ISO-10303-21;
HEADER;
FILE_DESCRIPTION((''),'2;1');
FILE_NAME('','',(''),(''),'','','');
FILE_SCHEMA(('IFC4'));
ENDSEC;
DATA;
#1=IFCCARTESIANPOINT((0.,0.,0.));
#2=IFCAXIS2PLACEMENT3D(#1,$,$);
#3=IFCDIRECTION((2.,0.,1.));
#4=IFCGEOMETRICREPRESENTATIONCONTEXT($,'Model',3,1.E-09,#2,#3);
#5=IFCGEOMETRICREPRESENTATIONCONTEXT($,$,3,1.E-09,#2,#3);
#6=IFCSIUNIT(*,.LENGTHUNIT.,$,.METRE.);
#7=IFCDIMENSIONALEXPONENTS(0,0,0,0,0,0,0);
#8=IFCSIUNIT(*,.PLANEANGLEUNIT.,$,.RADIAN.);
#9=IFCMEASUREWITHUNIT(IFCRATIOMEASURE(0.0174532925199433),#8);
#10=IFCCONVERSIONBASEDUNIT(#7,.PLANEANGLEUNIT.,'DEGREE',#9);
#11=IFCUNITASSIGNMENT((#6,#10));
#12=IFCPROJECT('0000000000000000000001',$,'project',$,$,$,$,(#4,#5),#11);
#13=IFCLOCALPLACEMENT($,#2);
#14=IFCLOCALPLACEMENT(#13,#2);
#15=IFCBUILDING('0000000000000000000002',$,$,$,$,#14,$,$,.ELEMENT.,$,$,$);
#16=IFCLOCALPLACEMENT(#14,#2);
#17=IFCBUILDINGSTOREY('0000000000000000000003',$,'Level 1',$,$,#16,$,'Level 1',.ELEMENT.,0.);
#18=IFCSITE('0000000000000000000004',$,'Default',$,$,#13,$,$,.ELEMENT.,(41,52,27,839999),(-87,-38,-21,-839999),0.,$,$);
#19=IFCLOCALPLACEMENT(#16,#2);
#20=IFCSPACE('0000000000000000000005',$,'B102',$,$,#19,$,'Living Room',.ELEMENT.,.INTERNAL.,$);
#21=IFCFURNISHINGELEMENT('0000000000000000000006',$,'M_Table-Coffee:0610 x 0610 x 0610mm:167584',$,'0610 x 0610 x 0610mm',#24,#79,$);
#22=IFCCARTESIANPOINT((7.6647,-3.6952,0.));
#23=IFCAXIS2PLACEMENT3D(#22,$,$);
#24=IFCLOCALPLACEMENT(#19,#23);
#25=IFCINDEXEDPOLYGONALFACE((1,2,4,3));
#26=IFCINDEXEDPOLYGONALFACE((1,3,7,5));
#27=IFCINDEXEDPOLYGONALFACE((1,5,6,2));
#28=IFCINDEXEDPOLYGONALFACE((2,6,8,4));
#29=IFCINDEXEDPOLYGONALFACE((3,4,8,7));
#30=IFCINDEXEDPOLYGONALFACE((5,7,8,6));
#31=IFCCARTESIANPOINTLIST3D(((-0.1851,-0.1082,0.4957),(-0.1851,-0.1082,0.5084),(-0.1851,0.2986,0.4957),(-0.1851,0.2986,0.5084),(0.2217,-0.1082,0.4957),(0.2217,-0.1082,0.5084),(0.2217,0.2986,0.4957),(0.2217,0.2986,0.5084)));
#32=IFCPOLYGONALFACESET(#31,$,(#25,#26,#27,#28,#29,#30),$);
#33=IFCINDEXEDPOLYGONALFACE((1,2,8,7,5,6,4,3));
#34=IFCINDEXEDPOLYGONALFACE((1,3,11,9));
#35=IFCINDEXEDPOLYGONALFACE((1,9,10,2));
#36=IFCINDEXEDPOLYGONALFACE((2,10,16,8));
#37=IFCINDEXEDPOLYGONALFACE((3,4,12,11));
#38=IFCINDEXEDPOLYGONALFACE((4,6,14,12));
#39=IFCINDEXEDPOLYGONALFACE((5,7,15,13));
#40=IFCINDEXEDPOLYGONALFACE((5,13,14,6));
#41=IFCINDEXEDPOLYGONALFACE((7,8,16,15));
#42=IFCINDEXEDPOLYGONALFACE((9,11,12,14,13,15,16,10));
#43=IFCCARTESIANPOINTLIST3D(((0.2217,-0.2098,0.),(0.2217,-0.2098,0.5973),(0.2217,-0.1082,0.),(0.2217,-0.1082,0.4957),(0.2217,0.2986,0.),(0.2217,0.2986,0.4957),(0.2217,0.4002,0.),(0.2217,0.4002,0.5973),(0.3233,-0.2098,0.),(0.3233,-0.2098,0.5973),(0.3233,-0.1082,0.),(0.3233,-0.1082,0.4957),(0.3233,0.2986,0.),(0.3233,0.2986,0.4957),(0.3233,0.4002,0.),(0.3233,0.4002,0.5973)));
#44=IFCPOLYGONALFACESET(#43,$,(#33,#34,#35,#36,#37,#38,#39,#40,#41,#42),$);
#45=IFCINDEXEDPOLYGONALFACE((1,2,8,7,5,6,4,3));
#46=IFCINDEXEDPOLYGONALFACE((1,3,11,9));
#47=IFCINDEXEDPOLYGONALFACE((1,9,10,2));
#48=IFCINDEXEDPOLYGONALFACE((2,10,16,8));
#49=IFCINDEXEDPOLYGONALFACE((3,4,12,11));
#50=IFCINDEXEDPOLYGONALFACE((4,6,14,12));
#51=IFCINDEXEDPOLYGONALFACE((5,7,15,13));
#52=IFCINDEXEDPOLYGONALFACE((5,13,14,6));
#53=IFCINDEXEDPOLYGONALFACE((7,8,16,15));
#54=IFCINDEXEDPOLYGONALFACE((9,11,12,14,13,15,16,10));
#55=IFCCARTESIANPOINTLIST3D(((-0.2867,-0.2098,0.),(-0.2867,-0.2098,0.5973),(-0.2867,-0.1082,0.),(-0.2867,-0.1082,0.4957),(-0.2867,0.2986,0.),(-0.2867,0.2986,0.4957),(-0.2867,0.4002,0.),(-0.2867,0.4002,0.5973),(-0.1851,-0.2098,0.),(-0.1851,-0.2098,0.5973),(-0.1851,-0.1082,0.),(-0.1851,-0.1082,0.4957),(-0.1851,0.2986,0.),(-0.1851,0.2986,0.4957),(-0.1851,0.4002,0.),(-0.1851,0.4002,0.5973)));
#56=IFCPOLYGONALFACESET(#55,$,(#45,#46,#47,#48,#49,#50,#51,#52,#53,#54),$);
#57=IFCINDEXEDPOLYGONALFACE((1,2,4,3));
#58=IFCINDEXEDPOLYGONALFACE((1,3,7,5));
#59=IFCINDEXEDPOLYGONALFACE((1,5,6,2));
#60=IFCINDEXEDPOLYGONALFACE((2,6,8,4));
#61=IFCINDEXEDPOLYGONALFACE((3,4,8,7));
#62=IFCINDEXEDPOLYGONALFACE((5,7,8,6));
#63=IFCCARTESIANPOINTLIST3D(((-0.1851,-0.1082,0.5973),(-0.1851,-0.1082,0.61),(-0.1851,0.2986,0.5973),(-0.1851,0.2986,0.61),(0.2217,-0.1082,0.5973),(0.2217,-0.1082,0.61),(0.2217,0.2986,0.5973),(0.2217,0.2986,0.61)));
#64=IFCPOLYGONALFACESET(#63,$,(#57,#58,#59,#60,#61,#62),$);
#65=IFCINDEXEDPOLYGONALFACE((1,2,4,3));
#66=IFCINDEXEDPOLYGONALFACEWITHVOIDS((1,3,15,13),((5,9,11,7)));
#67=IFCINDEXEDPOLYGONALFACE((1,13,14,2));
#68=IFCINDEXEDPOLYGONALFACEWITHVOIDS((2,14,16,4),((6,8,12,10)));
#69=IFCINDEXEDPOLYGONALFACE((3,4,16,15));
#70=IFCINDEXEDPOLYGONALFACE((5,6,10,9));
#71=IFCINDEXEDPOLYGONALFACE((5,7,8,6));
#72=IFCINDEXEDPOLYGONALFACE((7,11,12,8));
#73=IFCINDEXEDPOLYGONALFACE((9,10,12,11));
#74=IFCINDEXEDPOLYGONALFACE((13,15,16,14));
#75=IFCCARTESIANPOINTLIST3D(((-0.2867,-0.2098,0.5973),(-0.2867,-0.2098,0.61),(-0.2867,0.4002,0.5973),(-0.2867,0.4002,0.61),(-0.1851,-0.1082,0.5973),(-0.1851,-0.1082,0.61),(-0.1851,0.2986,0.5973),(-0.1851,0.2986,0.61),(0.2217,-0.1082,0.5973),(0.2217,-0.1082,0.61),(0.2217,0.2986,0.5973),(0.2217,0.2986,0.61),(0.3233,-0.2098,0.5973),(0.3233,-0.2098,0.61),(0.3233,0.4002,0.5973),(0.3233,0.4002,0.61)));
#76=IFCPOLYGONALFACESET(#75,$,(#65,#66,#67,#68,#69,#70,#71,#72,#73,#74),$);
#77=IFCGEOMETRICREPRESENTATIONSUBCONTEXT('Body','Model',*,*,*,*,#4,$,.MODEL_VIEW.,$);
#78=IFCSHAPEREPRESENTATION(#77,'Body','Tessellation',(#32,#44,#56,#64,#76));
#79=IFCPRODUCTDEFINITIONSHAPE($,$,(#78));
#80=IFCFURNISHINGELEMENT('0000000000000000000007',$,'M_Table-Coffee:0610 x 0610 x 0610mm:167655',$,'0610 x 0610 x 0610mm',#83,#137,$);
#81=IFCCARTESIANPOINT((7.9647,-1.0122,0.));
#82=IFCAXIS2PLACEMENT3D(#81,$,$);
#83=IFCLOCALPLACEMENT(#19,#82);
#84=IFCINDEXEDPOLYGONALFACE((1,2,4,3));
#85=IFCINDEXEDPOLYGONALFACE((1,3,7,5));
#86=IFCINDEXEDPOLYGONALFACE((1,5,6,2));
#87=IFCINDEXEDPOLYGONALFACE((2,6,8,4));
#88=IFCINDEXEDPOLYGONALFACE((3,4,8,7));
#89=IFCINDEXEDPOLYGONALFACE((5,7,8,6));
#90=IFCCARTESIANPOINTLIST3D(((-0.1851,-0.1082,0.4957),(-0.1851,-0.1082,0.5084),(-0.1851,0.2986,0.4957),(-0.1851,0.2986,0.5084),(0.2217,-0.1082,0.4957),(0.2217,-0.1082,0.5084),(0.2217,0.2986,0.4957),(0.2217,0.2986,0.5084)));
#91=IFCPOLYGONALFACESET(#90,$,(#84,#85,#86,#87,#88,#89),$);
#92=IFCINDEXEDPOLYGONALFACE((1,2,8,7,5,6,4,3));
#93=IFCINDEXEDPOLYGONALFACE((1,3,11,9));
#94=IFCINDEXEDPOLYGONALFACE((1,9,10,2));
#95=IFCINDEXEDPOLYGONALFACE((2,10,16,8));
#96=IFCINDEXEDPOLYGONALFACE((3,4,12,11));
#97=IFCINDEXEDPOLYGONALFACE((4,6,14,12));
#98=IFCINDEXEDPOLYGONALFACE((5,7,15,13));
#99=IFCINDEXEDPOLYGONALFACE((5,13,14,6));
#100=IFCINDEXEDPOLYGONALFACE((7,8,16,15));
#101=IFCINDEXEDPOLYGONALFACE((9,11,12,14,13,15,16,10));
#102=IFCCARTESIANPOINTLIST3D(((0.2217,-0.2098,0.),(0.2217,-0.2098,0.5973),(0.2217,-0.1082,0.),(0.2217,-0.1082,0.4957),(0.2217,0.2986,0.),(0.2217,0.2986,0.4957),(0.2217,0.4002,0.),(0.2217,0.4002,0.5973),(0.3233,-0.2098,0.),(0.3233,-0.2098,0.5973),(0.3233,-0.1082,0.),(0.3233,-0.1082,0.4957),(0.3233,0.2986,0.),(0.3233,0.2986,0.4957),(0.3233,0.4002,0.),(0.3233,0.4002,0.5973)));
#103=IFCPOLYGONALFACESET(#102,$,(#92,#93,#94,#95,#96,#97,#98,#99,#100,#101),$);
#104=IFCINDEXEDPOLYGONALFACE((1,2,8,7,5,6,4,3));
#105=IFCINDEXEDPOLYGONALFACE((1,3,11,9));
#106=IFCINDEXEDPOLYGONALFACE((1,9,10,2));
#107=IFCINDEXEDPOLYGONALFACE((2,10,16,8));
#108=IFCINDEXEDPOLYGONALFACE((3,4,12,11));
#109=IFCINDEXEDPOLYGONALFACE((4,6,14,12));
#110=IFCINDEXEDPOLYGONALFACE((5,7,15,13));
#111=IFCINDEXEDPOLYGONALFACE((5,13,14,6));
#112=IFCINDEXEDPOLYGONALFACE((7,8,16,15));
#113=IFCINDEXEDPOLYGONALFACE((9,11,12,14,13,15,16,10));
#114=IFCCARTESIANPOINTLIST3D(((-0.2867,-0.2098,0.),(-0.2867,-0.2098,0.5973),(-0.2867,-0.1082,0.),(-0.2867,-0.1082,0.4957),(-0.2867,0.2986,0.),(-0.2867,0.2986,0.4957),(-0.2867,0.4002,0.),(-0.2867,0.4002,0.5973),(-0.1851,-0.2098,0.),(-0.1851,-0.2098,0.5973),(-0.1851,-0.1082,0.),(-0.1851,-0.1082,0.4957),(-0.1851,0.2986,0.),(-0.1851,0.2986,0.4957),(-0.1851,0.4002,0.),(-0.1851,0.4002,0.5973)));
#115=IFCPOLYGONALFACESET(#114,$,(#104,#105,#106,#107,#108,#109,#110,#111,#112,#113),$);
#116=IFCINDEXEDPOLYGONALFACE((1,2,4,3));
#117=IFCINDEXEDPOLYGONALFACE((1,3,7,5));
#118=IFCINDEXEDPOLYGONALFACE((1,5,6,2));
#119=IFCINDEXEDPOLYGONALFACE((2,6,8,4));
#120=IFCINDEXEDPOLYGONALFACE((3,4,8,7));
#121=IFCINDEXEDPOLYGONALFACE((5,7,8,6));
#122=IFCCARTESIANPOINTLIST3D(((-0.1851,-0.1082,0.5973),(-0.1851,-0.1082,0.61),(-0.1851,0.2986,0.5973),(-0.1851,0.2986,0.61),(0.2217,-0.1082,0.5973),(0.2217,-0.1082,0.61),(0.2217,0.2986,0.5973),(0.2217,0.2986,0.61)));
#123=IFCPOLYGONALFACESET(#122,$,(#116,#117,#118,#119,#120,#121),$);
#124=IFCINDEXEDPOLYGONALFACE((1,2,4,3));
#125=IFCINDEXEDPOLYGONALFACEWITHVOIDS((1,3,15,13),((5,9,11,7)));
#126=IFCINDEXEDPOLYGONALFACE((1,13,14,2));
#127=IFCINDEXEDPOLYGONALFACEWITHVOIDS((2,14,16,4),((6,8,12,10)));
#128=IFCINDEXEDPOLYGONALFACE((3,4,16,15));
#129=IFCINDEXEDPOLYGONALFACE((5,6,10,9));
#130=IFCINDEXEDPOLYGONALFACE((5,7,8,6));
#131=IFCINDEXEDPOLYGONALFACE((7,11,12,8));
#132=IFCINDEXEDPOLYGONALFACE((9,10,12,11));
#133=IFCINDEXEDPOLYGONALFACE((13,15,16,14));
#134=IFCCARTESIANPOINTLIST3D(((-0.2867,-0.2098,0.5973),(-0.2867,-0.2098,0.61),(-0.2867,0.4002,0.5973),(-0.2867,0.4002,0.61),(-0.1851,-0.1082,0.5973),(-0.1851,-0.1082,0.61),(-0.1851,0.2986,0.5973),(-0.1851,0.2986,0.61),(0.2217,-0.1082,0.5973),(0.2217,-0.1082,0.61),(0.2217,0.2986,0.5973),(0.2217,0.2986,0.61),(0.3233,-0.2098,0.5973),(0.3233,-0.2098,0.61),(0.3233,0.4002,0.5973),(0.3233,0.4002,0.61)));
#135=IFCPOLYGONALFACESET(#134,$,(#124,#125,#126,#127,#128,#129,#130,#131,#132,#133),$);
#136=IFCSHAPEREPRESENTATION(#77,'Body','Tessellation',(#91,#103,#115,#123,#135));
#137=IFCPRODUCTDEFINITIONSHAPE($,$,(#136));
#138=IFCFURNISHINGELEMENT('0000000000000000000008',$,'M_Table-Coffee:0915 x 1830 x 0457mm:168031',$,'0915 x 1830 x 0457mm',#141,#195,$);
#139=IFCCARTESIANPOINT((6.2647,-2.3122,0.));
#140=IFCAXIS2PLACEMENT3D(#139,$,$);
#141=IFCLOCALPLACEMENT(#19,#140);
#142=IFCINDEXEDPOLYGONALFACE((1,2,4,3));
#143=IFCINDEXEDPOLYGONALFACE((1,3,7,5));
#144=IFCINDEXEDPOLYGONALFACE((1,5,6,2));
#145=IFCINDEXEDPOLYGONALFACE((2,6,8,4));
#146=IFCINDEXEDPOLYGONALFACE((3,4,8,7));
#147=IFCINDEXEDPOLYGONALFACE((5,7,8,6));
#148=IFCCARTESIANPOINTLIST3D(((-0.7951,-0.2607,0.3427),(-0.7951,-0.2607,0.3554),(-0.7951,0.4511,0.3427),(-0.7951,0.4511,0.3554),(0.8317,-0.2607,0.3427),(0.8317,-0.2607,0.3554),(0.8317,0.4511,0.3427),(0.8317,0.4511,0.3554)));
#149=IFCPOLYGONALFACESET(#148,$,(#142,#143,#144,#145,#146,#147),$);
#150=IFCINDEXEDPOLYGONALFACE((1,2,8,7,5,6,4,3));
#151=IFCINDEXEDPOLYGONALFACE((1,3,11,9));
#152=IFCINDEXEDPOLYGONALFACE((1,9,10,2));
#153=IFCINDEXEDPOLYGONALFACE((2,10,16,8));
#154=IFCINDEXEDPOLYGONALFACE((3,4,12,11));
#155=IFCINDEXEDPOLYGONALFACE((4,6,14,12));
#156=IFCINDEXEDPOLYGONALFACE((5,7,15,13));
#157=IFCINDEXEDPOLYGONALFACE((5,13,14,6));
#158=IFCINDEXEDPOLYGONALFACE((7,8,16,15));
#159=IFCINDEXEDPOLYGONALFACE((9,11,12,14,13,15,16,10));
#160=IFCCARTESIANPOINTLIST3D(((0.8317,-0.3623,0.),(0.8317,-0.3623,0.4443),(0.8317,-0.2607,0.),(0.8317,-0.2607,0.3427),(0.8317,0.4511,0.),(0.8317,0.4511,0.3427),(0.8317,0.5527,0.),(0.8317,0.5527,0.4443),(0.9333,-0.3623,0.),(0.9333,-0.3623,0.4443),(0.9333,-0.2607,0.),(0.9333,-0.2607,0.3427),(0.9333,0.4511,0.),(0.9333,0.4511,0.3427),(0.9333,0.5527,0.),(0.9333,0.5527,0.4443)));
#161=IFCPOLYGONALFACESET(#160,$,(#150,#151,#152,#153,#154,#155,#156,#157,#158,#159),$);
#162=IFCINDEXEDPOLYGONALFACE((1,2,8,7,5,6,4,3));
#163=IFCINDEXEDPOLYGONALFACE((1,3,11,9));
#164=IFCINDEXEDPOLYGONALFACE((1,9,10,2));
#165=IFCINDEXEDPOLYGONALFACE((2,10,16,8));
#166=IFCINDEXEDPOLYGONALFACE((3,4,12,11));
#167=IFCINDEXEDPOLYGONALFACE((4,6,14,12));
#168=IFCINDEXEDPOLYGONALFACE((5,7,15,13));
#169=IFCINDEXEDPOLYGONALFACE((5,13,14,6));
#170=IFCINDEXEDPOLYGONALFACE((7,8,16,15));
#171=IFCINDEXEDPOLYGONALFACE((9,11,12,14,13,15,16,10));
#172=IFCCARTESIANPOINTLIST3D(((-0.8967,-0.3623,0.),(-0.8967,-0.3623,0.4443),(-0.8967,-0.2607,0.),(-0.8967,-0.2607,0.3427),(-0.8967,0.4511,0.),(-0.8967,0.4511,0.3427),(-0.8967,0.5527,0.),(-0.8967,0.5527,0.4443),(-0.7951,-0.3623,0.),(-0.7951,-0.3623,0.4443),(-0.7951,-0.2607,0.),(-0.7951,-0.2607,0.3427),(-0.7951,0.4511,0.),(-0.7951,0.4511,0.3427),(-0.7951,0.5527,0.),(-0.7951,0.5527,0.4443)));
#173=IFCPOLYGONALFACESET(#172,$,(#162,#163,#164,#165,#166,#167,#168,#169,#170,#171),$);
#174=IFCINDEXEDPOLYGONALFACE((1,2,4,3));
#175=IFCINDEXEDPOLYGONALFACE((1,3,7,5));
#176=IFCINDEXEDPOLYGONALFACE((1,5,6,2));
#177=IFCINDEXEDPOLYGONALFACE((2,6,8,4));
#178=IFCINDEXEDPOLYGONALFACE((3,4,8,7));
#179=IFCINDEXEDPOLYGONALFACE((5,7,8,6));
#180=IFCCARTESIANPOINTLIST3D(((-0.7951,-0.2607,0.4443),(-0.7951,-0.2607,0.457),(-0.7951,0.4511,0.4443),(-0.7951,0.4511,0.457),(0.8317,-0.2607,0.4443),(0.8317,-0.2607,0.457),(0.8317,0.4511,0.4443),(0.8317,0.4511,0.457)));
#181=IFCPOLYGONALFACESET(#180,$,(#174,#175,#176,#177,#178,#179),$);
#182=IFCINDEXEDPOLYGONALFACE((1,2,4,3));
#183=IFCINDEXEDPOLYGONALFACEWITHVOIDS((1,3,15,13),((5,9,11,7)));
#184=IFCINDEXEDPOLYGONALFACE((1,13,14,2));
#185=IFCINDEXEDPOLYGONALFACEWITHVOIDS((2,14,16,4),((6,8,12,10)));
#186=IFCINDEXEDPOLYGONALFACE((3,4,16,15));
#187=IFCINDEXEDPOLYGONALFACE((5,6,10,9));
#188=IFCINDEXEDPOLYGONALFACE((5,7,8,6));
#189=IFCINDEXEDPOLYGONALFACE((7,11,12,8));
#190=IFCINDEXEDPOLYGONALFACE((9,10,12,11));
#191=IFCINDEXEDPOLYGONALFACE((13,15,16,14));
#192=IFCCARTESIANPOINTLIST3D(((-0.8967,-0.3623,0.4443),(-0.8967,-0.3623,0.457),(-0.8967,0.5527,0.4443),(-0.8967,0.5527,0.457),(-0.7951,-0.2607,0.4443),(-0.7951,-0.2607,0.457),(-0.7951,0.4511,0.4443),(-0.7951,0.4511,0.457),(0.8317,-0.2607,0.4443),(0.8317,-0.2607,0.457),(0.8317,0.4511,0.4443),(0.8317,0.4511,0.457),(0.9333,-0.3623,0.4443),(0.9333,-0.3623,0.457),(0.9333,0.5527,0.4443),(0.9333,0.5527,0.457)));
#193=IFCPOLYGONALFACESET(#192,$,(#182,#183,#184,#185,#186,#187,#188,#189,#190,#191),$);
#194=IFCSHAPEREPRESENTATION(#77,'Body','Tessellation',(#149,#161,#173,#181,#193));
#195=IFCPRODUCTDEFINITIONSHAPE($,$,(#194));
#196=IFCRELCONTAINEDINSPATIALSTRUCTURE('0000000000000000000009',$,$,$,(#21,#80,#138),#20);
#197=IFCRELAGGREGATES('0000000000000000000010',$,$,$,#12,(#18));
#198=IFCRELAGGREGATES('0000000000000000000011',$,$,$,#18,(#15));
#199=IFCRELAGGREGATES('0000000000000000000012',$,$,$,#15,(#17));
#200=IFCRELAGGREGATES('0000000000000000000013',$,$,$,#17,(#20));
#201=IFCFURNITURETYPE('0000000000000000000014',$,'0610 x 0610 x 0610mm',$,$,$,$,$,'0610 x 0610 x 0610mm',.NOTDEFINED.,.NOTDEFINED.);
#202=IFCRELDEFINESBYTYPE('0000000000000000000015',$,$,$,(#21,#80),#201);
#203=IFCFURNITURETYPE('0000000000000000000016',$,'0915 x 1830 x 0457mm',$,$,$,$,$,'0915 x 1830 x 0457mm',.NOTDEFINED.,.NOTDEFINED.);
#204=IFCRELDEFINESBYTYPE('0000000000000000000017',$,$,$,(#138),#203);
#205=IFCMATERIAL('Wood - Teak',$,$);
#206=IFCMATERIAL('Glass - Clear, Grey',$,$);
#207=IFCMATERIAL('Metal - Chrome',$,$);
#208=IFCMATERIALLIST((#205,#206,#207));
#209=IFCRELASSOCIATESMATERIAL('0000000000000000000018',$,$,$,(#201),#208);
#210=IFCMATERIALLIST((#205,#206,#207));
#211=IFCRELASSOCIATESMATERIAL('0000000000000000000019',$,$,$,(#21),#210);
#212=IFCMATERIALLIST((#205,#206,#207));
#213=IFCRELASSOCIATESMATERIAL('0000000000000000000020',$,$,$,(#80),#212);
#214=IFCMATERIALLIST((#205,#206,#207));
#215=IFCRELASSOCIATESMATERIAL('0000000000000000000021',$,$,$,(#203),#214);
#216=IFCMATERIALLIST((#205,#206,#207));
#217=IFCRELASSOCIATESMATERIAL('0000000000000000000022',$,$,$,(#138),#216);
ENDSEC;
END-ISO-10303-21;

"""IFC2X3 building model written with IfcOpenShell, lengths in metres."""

from ifc_helpers import new_model, entity, si_unit, converted_unit, direction, frame, origin, origin_2d_with_axis, place, context, subcontext, project, spatial, polyline, rectangle, outline, extrude, source, transform, mapped, material, material_list, type_object, type_shapes, element, save


model = new_model("IFC2X3")

# Units and contexts
model_context = context("Model", 3, precision=1e-09, world=origin(), true_north=direction((2.0, 0.0, 1.0)))
context_of_model = context(None, 3, precision=1e-09, world=origin(), true_north=direction((2.0, 0.0, 1.0)))
body_context = subcontext(model_context, "Body", "Model", "MODEL_VIEW")
ifc_project = project(units=[si_unit("LENGTHUNIT", "METRE"), converted_unit("PLANEANGLEUNIT", "DEGREE", entity("IfcRatioMeasure", 0.0174532925199433), si_unit("PLANEANGLEUNIT", "RADIAN"), dimensions=[0, 0, 0, 0, 0, 0, 0])], contexts=[model_context, context_of_model])

# Site, building, storey
site_placement = place(None, origin())
site = spatial("IfcSite", under=ifc_project, at=site_placement, Name="Default", CompositionType="ELEMENT", RefLatitude=(41, 52, 27, 839999), RefLongitude=(-87, -38, -21, -839999), RefElevation=0.0)
building_placement = place(site_placement, origin())
building = spatial("IfcBuilding", under=site, at=building_placement, CompositionType="ELEMENT")
storey_placement = place(building_placement, origin())
storey = spatial("IfcBuildingStorey", under=building, at=storey_placement, Name="Level 1", LongName="Level 1", CompositionType="ELEMENT", Elevation=0.0)

# Shared definitions
space_1_placement = place(storey_placement, origin())
space_1 = spatial("IfcSpace", under=storey, at=space_1_placement, Name="B102", LongName="Living Room", CompositionType="ELEMENT", InteriorOrExteriorSpace="INTERNAL")

# Furnishing elements
ifc_material_1 = material(Name="Wood - Teak")
ifc_material_2 = material(Name="Glass - Clear, Grey")
ifc_material_3 = material(Name="Metal - Chrome")
ifc_material_list_1 = material_list([ifc_material_1, ifc_material_2, ifc_material_3])
ifc_material_list_2 = material_list([ifc_material_1, ifc_material_2, ifc_material_3])
furniture_type_1 = type_object("IfcFurnitureType", Name="0610 x 0610 x 0610mm", ElementType="0610 x 0610 x 0610mm", AssemblyPlace="NOTDEFINED", material=ifc_material_list_2)
shared_shape_1 = source(origin(), body_context, "Body", "SweptSolid", [
    extrude(rectangle(XDim=0.4068, YDim=0.4068, at=origin_2d_with_axis()), frame((0.0183, 0.0952, 0.4957), z_axis=(0.0, 0.0, 1.0), x_axis=(-1.0, 0.0, 0.0)), (0.0, 0.0, 1.0), 0.0127),
    extrude(outline(polyline([(-0.2732, -0.305), (0.324, -0.305), (0.324, 0.305), (-0.2732, 0.305), (-0.2732, 0.2034), (0.2225, 0.2034), (0.2225, -0.2034), (-0.2732, -0.2034), (-0.2732, -0.305)])), frame((0.2217, 0.0952, 0.2732), z_axis=(1.0, 0.0, 0.0), x_axis=(0.0, 0.0, 1.0)), (0.0, 0.0, 1.0), 0.1016),
    extrude(outline(polyline([(-0.305, -0.3241), (0.305, -0.3241), (0.305, 0.2733), (0.2034, 0.2733), (0.2034, -0.2224), (-0.2034, -0.2224), (-0.2034, 0.2733), (-0.305, 0.2733), (-0.305, -0.3241)])), frame((-0.2867, 0.0952, 0.2733), z_axis=(1.0, 0.0, 0.0), x_axis=(0.0, -1.0, 0.0)), (0.0, 0.0, 1.0), 0.1016),
    extrude(rectangle(XDim=0.4068, YDim=0.4068, at=origin_2d_with_axis()), frame((0.0183, 0.0952, 0.5973), z_axis=(0.0, 0.0, 1.0), x_axis=(-1.0, 0.0, 0.0)), (0.0, 0.0, 1.0), 0.0127),
    extrude(outline(polyline([(-0.305, -0.305), (0.305, -0.305), (0.305, 0.305), (-0.305, 0.305), (-0.305, -0.305)]), holes=[polyline([(-0.2034, -0.2034), (-0.2034, 0.2034), (0.2034, 0.2034), (0.2034, -0.2034), (-0.2034, -0.2034)])]), frame((0.0183, 0.0952, 0.5973), z_axis=(0.0, 0.0, 1.0), x_axis=(-1.0, 0.0, 0.0)), (0.0, 0.0, 1.0), 0.0127),
])
type_shapes(furniture_type_1, [shared_shape_1])
furnishing_1_placement = place(space_1_placement, frame((7.6647, -3.6952, 0.0)))
element("IfcFurnishingElement", 1, at=furnishing_1_placement, inside=space_1, type_object=furniture_type_1, material=ifc_material_list_1, Name="M_Table-Coffee:0610 x 0610 x 0610mm:167584", ObjectType="0610 x 0610 x 0610mm", context=body_context, shape_type="MappedRepresentation", body=[
    mapped(shared_shape_1, transform((0.0, 0.0, 0.0), scale=1.0)),
])
ifc_material_list_3 = material_list([ifc_material_1, ifc_material_2, ifc_material_3])
furnishing_2_placement = place(space_1_placement, frame((7.9647, -1.0122, 0.0)))
element("IfcFurnishingElement", 2, at=furnishing_2_placement, inside=space_1, type_object=furniture_type_1, material=ifc_material_list_3, Name="M_Table-Coffee:0610 x 0610 x 0610mm:167655", ObjectType="0610 x 0610 x 0610mm", context=body_context, shape_type="MappedRepresentation", body=[
    mapped(shared_shape_1, transform((0.0, 0.0, 0.0), scale=1.0)),
])
ifc_material_list_4 = material_list([ifc_material_1, ifc_material_2, ifc_material_3])
ifc_material_list_5 = material_list([ifc_material_1, ifc_material_2, ifc_material_3])
furniture_type_2 = type_object("IfcFurnitureType", Name="0915 x 1830 x 0457mm", ElementType="0915 x 1830 x 0457mm", AssemblyPlace="NOTDEFINED", material=ifc_material_list_5)
shared_shape_2 = source(origin(), body_context, "Body", "SweptSolid", [
    extrude(rectangle(XDim=1.6268, YDim=0.7118, at=origin_2d_with_axis()), frame((0.0183, 0.0952, 0.3427), z_axis=(0.0, 0.0, 1.0), x_axis=(-1.0, 0.0, 0.0)), (0.0, 0.0, 1.0), 0.0127),
    extrude(outline(polyline([(-0.1967, -0.4575), (0.2475, -0.4575), (0.2475, 0.4575), (-0.1967, 0.4575), (-0.1967, 0.3559), (0.146, 0.3559), (0.146, -0.3559), (-0.1967, -0.3559), (-0.1967, -0.4575)])), frame((0.8317, 0.0952, 0.1967), z_axis=(1.0, 0.0, 0.0), x_axis=(0.0, 0.0, 1.0)), (0.0, 0.0, 1.0), 0.1016),
    extrude(outline(polyline([(-0.4575, -0.2476), (0.4575, -0.2476), (0.4575, 0.1968), (0.3559, 0.1968), (0.3559, -0.1459), (-0.3559, -0.1459), (-0.3559, 0.1968), (-0.4575, 0.1968), (-0.4575, -0.2476)])), frame((-0.8967, 0.0952, 0.1968), z_axis=(1.0, 0.0, 0.0), x_axis=(0.0, -1.0, 0.0)), (0.0, 0.0, 1.0), 0.1016),
    extrude(rectangle(XDim=1.6268, YDim=0.7118, at=origin_2d_with_axis()), frame((0.0183, 0.0952, 0.4443), z_axis=(0.0, 0.0, 1.0), x_axis=(-1.0, 0.0, 0.0)), (0.0, 0.0, 1.0), 0.0127),
    extrude(outline(polyline([(-0.915, -0.4575), (0.915, -0.4575), (0.915, 0.4575), (-0.915, 0.4575), (-0.915, -0.4575)]), holes=[polyline([(-0.8134, -0.3559), (-0.8134, 0.3559), (0.8134, 0.3559), (0.8134, -0.3559), (-0.8134, -0.3559)])]), frame((0.0183, 0.0952, 0.4443), z_axis=(0.0, 0.0, 1.0), x_axis=(-1.0, 0.0, 0.0)), (0.0, 0.0, 1.0), 0.0127),
])
type_shapes(furniture_type_2, [shared_shape_2])
furnishing_3_placement = place(space_1_placement, frame((6.2647, -2.3122, 0.0)))
element("IfcFurnishingElement", 3, at=furnishing_3_placement, inside=space_1, type_object=furniture_type_2, material=ifc_material_list_4, Name="M_Table-Coffee:0915 x 1830 x 0457mm:168031", ObjectType="0915 x 1830 x 0457mm", context=body_context, shape_type="MappedRepresentation", body=[
    mapped(shared_shape_2, transform((0.0, 0.0, 0.0), scale=1.0)),
])

save(model, "model.ifc")
